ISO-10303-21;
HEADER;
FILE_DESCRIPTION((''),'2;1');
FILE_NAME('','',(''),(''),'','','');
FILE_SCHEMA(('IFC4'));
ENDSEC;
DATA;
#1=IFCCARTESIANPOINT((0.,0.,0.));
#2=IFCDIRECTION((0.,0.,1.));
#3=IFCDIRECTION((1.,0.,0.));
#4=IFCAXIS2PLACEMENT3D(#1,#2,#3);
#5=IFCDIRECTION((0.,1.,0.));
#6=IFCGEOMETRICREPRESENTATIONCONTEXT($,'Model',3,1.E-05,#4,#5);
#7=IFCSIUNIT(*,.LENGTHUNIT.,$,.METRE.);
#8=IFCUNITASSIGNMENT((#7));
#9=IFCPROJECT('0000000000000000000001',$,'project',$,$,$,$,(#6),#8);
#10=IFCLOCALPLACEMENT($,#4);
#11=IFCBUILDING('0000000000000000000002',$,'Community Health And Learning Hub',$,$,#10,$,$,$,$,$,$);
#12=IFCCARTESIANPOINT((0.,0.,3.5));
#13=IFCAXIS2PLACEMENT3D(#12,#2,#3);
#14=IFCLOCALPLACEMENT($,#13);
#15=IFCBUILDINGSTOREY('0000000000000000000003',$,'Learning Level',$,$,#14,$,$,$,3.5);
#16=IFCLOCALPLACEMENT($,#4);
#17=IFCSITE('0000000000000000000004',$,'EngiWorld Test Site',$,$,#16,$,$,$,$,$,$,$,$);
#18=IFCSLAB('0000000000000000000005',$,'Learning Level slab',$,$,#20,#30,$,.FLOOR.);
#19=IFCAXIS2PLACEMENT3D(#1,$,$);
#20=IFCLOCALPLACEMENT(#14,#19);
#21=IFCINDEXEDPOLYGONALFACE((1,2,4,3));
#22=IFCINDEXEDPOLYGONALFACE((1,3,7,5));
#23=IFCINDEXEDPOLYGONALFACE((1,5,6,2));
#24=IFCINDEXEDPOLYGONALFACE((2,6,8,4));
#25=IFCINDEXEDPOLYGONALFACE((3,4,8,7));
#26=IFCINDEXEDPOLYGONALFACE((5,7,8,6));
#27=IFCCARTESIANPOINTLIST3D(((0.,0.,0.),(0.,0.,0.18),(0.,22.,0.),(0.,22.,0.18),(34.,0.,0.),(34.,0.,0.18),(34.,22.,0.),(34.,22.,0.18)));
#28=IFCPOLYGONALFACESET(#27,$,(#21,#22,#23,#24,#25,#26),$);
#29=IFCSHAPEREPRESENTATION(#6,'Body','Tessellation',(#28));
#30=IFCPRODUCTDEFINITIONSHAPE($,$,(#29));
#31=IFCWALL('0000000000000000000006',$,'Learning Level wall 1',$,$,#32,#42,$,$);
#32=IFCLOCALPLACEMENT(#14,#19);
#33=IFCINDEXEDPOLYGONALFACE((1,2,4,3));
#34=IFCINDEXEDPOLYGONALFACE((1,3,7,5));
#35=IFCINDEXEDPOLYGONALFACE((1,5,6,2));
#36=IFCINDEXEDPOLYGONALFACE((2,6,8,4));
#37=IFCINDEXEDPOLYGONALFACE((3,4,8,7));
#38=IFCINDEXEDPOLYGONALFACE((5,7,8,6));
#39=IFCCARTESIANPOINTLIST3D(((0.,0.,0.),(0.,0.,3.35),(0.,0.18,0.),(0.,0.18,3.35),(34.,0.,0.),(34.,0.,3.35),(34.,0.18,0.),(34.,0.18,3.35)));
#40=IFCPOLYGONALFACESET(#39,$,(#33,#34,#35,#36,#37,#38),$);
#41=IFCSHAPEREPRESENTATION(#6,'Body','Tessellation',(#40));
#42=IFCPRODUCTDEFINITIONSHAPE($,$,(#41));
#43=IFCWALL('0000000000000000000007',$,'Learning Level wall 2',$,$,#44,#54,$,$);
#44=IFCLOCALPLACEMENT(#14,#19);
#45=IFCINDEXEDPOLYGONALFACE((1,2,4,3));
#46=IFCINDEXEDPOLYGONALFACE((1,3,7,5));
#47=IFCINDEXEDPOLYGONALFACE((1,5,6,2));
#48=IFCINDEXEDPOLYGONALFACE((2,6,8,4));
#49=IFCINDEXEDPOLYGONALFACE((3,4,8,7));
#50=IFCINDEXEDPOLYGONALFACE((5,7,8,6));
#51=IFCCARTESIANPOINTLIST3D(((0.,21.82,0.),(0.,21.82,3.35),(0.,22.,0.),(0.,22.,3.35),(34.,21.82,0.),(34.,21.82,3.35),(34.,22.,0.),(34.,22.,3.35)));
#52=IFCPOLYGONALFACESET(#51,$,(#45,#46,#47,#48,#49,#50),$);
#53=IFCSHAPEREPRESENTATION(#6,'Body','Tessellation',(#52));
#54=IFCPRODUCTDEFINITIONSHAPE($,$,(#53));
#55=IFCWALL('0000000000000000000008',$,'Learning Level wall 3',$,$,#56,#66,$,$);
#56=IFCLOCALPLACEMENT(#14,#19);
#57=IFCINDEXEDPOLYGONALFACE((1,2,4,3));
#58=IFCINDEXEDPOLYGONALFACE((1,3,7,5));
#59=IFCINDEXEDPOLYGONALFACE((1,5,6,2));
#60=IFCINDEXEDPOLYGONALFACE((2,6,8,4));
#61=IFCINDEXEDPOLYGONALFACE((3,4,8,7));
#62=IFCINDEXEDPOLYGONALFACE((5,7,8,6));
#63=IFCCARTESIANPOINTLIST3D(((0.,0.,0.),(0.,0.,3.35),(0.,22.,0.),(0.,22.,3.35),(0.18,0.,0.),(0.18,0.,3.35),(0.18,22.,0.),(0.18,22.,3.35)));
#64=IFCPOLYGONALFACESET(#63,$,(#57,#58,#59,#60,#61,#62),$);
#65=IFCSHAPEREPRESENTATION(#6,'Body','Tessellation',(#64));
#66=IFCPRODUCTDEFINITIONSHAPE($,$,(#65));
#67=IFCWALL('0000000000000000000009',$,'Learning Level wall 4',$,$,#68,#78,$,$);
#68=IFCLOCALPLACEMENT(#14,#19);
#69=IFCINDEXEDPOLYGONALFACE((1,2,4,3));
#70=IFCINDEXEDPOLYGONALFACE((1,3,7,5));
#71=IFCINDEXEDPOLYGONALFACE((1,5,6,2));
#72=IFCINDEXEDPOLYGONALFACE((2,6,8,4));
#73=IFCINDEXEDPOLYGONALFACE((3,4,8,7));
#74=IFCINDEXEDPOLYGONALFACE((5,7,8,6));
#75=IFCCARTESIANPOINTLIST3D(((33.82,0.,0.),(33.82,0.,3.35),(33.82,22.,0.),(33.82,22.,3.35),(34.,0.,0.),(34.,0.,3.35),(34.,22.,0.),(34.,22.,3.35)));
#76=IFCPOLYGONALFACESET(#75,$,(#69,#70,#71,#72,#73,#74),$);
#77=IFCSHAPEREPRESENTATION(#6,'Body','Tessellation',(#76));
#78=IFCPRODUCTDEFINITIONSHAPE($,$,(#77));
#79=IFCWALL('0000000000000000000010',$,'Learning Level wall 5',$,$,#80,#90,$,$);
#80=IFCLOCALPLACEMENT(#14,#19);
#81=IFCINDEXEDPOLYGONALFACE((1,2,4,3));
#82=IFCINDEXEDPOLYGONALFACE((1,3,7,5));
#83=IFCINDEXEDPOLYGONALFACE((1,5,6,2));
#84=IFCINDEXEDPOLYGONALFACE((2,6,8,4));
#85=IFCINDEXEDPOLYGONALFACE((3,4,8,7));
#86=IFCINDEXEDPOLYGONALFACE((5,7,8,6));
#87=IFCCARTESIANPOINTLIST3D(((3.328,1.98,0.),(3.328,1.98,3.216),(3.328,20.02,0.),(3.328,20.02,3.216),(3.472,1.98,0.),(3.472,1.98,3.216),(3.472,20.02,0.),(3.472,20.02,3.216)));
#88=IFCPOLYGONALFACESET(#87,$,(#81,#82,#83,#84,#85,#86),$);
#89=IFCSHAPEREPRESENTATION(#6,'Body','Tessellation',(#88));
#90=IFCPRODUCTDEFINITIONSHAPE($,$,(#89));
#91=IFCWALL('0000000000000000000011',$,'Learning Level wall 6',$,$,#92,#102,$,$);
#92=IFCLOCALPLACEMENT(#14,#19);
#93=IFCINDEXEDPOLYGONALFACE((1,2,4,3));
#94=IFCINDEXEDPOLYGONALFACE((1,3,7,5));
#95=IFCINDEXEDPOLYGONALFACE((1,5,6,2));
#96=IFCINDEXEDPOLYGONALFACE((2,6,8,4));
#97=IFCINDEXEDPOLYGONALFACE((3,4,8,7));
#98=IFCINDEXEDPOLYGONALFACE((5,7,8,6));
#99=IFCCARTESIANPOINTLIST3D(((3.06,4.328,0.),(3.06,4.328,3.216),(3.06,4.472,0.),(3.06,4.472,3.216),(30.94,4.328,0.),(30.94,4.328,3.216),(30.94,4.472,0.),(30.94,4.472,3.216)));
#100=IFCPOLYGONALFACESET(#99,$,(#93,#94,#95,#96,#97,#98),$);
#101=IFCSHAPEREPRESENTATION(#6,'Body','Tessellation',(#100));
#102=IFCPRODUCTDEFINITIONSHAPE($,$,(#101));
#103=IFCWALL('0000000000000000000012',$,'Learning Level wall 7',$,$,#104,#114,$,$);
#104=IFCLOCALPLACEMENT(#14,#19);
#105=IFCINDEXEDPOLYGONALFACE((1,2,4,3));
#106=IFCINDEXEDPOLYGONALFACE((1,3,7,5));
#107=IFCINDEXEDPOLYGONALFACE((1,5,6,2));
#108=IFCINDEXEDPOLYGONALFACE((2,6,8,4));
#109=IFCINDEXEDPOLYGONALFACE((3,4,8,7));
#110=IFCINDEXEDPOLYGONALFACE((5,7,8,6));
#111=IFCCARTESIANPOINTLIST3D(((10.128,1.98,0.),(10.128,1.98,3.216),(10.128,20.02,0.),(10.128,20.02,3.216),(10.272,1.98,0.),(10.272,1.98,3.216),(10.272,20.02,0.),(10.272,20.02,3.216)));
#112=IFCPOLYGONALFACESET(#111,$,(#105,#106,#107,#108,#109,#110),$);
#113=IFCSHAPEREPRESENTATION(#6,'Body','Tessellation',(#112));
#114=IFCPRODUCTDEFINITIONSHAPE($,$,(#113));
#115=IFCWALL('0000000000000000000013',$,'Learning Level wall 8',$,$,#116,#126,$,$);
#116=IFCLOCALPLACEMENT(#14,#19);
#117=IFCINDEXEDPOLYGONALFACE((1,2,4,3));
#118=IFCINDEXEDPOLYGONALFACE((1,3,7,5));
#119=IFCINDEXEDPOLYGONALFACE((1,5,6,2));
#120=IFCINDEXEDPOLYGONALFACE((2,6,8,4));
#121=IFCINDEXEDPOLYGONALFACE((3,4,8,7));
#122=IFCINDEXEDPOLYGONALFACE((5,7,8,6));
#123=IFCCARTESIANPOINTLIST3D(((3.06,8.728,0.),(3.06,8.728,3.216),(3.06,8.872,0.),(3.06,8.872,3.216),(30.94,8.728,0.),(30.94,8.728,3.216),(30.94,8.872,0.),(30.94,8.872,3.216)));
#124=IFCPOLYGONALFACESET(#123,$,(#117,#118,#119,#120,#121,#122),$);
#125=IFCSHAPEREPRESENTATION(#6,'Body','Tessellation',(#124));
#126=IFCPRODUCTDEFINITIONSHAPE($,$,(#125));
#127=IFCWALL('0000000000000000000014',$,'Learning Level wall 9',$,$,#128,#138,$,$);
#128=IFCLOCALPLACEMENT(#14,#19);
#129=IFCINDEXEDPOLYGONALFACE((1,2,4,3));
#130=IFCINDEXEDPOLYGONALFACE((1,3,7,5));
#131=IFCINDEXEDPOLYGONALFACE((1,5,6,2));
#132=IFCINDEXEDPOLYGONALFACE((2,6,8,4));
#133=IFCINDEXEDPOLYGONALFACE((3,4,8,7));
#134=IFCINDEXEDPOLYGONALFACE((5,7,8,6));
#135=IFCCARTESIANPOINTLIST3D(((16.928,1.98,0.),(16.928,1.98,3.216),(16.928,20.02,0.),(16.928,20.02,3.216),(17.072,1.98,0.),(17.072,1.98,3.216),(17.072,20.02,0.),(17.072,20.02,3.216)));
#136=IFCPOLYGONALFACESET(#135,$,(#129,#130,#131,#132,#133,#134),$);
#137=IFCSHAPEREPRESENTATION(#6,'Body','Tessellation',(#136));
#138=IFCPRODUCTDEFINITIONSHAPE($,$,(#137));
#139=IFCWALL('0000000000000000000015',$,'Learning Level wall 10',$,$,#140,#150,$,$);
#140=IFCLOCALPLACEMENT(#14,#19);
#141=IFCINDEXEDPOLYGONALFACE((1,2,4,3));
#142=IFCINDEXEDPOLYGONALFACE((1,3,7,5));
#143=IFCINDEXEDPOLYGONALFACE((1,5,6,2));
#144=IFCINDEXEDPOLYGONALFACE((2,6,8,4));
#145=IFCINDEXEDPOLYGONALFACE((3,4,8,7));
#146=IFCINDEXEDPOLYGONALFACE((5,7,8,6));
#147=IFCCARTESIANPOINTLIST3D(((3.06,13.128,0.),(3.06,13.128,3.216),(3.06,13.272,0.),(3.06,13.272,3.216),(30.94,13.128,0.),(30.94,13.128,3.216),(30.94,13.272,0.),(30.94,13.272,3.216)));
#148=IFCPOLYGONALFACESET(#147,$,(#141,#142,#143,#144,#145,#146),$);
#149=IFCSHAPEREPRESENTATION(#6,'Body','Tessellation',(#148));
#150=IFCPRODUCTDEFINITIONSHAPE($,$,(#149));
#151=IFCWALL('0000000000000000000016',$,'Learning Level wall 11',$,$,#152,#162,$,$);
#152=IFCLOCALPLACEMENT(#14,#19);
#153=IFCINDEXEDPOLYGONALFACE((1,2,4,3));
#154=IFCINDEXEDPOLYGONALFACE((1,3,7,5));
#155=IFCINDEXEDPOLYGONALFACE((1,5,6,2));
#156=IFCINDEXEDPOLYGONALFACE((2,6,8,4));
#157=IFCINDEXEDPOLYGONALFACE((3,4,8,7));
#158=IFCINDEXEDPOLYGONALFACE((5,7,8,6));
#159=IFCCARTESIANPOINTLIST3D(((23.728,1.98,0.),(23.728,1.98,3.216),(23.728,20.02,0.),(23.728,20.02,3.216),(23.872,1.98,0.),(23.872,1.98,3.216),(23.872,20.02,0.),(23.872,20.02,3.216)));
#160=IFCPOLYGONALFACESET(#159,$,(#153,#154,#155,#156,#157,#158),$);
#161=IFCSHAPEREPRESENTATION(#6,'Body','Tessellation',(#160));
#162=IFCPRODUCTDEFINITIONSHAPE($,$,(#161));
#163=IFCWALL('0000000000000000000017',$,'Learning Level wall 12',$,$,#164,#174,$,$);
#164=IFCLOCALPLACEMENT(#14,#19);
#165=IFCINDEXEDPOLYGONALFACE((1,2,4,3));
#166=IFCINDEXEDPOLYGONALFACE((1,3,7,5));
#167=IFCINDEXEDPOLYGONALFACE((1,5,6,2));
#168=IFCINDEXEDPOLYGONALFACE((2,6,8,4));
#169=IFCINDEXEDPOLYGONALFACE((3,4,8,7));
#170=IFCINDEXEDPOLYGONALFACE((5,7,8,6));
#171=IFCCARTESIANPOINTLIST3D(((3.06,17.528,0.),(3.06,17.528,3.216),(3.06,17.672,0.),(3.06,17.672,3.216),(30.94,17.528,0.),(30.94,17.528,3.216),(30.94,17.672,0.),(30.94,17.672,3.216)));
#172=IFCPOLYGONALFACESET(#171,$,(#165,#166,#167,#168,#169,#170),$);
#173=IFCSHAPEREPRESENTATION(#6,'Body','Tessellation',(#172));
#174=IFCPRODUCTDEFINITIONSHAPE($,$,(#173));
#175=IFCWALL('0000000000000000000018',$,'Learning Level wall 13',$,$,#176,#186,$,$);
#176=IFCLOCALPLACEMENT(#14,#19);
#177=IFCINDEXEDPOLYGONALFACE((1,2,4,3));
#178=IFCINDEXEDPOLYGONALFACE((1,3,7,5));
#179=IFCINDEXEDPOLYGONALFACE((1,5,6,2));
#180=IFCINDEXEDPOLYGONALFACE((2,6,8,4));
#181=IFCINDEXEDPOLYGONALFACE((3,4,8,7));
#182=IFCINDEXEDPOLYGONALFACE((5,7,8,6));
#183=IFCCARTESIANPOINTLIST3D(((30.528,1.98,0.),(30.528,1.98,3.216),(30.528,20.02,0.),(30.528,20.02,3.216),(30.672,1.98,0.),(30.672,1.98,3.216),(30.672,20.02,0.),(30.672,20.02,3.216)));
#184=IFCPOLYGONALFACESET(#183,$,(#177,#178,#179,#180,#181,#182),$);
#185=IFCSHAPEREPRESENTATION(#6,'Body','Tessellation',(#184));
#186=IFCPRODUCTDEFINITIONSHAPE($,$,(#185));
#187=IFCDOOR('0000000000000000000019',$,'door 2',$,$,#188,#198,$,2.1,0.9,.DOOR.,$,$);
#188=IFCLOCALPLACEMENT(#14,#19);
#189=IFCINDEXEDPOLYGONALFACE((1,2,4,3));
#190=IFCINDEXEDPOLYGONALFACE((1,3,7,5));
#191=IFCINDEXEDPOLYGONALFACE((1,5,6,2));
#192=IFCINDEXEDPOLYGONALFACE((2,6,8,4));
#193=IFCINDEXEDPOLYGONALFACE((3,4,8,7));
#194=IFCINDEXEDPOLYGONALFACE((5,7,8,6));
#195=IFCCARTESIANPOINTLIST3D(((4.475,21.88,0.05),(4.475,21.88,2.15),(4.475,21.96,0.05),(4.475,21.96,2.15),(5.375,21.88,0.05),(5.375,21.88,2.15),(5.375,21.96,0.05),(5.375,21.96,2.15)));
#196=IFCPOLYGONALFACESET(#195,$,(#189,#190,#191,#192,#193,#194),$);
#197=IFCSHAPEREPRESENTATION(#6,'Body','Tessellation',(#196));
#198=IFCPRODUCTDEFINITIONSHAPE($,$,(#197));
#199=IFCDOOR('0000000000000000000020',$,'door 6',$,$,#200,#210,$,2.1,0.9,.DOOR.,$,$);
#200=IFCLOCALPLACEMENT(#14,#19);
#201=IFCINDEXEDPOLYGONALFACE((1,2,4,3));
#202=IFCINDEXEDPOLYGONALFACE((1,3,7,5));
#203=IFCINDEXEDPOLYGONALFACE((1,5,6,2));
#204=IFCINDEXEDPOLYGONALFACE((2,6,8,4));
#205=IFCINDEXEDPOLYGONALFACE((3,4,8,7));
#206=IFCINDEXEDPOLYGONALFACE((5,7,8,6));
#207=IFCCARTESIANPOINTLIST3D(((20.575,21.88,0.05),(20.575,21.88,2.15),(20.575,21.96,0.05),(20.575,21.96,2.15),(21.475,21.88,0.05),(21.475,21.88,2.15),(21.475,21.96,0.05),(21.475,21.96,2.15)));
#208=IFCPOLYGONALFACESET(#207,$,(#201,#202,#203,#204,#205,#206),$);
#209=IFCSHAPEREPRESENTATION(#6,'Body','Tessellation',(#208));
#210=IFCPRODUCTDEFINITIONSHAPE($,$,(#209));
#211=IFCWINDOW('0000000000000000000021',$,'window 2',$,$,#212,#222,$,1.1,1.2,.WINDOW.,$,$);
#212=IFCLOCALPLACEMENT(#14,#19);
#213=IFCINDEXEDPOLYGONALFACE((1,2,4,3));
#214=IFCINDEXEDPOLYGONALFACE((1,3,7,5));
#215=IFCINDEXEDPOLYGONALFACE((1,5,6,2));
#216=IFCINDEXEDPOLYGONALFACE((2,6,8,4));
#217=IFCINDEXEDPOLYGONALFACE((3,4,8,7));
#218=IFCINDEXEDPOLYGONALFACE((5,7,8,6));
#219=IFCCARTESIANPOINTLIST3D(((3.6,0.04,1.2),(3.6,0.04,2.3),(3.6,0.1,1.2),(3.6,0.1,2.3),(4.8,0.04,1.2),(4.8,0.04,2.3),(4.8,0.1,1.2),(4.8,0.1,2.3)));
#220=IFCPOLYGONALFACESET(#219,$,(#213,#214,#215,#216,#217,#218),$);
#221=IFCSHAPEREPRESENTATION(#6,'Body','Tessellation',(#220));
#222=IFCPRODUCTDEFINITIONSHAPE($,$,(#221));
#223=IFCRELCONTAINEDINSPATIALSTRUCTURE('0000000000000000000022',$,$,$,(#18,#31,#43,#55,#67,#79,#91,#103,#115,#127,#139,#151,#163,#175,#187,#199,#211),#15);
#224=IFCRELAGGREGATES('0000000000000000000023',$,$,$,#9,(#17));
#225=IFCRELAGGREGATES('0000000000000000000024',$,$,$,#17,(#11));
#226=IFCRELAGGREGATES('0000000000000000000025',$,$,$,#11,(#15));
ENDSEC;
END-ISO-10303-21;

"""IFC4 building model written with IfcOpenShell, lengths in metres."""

from ifc_helpers import new_model, si_unit, direction, frame, origin_with_axes, origin_2d_with_axis, place, context, project, spatial, rectangle, extrude, element, save


model = new_model("IFC4")

# Units and contexts
model_context = context("Model", 3, precision=1e-05, world=origin_with_axes(), true_north=direction((0.0, 1.0, 0.0)))
ifc_project = project(units=[si_unit("LENGTHUNIT", "METRE")], contexts=[model_context])

# Site, building, storey
site_placement = place(None, origin_with_axes())
site = spatial("IfcSite", under=ifc_project, at=site_placement, Name="EngiWorld Test Site")
building_placement = place(None, origin_with_axes())
building = spatial("IfcBuilding", under=site, at=building_placement, Name="Community Health And Learning Hub")
storey_placement = place(None, frame((0.0, 0.0, 3.5), z_axis=(0.0, 0.0, 1.0), x_axis=(1.0, 0.0, 0.0)))
storey = spatial("IfcBuildingStorey", under=building, at=storey_placement, Name="Learning Level", Elevation=3.5)

# Slab
slab_placement = place(None, frame((17.0, 11.0, 3.5), z_axis=(0.0, 0.0, 1.0), x_axis=(1.0, 0.0, 0.0)))
element("IfcSlab", 1, at=slab_placement, inside=storey, Name="Learning Level slab", PredefinedType="FLOOR", context=model_context, shape_type="SweptSolid", body=[
    extrude(rectangle(XDim=34.0, YDim=22.0, at=origin_2d_with_axis()), origin_with_axes(), (0.0, 0.0, 1.0), 0.18),
])

# Walls
for number, where, z_axis, x_axis, name in (
    (2, (17.0, 0.09, 3.5), (0.0, 0.0, 1.0), (1.0, 0.0, 0.0), "Learning Level wall 1"),
    (3, (17.0, 21.91, 3.5), (0.0, 0.0, 1.0), (1.0, 0.0, 0.0), "Learning Level wall 2"),
):
    element("IfcWall", number, at=place(None, frame(where, z_axis=z_axis, x_axis=x_axis)), inside=storey, Name=name, context=model_context, shape_type="SweptSolid", body=[
        extrude(rectangle(XDim=34.0, YDim=0.18, at=origin_2d_with_axis()), origin_with_axes(), (0.0, 0.0, 1.0), 3.35),
    ])
for number, where, z_axis, x_axis, name in (
    (4, (0.09, 11.0, 3.5), (0.0, 0.0, 1.0), (1.0, 0.0, 0.0), "Learning Level wall 3"),
    (5, (33.91, 11.0, 3.5), (0.0, 0.0, 1.0), (1.0, 0.0, 0.0), "Learning Level wall 4"),
):
    element("IfcWall", number, at=place(None, frame(where, z_axis=z_axis, x_axis=x_axis)), inside=storey, Name=name, context=model_context, shape_type="SweptSolid", body=[
        extrude(rectangle(XDim=0.18, YDim=22.0, at=origin_2d_with_axis()), origin_with_axes(), (0.0, 0.0, 1.0), 3.35),
    ])
wall_1_placement = place(None, frame((3.4, 11.0, 3.5), z_axis=(0.0, 0.0, 1.0), x_axis=(1.0, 0.0, 0.0)))
element("IfcWall", 6, at=wall_1_placement, inside=storey, Name="Learning Level wall 5", context=model_context, shape_type="SweptSolid", body=[
    extrude(rectangle(XDim=0.144, YDim=18.04, at=origin_2d_with_axis()), origin_with_axes(), (0.0, 0.0, 1.0), 3.216),
])
wall_2_placement = place(None, frame((17.0, 4.4, 3.5), z_axis=(0.0, 0.0, 1.0), x_axis=(1.0, 0.0, 0.0)))
element("IfcWall", 7, at=wall_2_placement, inside=storey, Name="Learning Level wall 6", context=model_context, shape_type="SweptSolid", body=[
    extrude(rectangle(XDim=27.88, YDim=0.144, at=origin_2d_with_axis()), origin_with_axes(), (0.0, 0.0, 1.0), 3.216),
])
wall_3_placement = place(None, frame((10.2, 11.0, 3.5), z_axis=(0.0, 0.0, 1.0), x_axis=(1.0, 0.0, 0.0)))
element("IfcWall", 8, at=wall_3_placement, inside=storey, Name="Learning Level wall 7", context=model_context, shape_type="SweptSolid", body=[
    extrude(rectangle(XDim=0.144, YDim=18.04, at=origin_2d_with_axis()), origin_with_axes(), (0.0, 0.0, 1.0), 3.216),
])
wall_4_placement = place(None, frame((17.0, 8.8, 3.5), z_axis=(0.0, 0.0, 1.0), x_axis=(1.0, 0.0, 0.0)))
element("IfcWall", 9, at=wall_4_placement, inside=storey, Name="Learning Level wall 8", context=model_context, shape_type="SweptSolid", body=[
    extrude(rectangle(XDim=27.88, YDim=0.144, at=origin_2d_with_axis()), origin_with_axes(), (0.0, 0.0, 1.0), 3.216),
])
wall_5_placement = place(None, frame((17.0, 11.0, 3.5), z_axis=(0.0, 0.0, 1.0), x_axis=(1.0, 0.0, 0.0)))
element("IfcWall", 10, at=wall_5_placement, inside=storey, Name="Learning Level wall 9", context=model_context, shape_type="SweptSolid", body=[
    extrude(rectangle(XDim=0.144, YDim=18.04, at=origin_2d_with_axis()), origin_with_axes(), (0.0, 0.0, 1.0), 3.216),
])
wall_6_placement = place(None, frame((17.0, 13.2, 3.5), z_axis=(0.0, 0.0, 1.0), x_axis=(1.0, 0.0, 0.0)))
element("IfcWall", 11, at=wall_6_placement, inside=storey, Name="Learning Level wall 10", context=model_context, shape_type="SweptSolid", body=[
    extrude(rectangle(XDim=27.88, YDim=0.144, at=origin_2d_with_axis()), origin_with_axes(), (0.0, 0.0, 1.0), 3.216),
])
wall_7_placement = place(None, frame((23.8, 11.0, 3.5), z_axis=(0.0, 0.0, 1.0), x_axis=(1.0, 0.0, 0.0)))
element("IfcWall", 12, at=wall_7_placement, inside=storey, Name="Learning Level wall 11", context=model_context, shape_type="SweptSolid", body=[
    extrude(rectangle(XDim=0.144, YDim=18.04, at=origin_2d_with_axis()), origin_with_axes(), (0.0, 0.0, 1.0), 3.216),
])
wall_8_placement = place(None, frame((17.0, 17.6, 3.5), z_axis=(0.0, 0.0, 1.0), x_axis=(1.0, 0.0, 0.0)))
element("IfcWall", 13, at=wall_8_placement, inside=storey, Name="Learning Level wall 12", context=model_context, shape_type="SweptSolid", body=[
    extrude(rectangle(XDim=27.88, YDim=0.144, at=origin_2d_with_axis()), origin_with_axes(), (0.0, 0.0, 1.0), 3.216),
])
wall_9_placement = place(None, frame((30.6, 11.0, 3.5), z_axis=(0.0, 0.0, 1.0), x_axis=(1.0, 0.0, 0.0)))
element("IfcWall", 14, at=wall_9_placement, inside=storey, Name="Learning Level wall 13", context=model_context, shape_type="SweptSolid", body=[
    extrude(rectangle(XDim=0.144, YDim=18.04, at=origin_2d_with_axis()), origin_with_axes(), (0.0, 0.0, 1.0), 3.216),
])

# Doors
for number, where, z_axis, x_axis, name in (
    (15, (4.925, 21.92, 3.55), (0.0, 0.0, 1.0), (1.0, 0.0, 0.0), "door 2"),
    (16, (21.025, 21.92, 3.55), (0.0, 0.0, 1.0), (1.0, 0.0, 0.0), "door 6"),
):
    element("IfcDoor", number, at=place(None, frame(where, z_axis=z_axis, x_axis=x_axis)), inside=storey, Name=name, OverallHeight=2.1, OverallWidth=0.9, PredefinedType="DOOR", context=model_context, shape_type="SweptSolid", body=[
        extrude(rectangle(XDim=0.9, YDim=0.08, at=origin_2d_with_axis()), origin_with_axes(), (0.0, 0.0, 1.0), 2.1),
    ])

# Window
for number, where, z_axis, x_axis, name in (
    (17, (4.2, 0.07, 4.7), (0.0, 0.0, 1.0), (1.0, 0.0, 0.0), "window 2"),
):
    element("IfcWindow", number, at=place(None, frame(where, z_axis=z_axis, x_axis=x_axis)), inside=storey, Name=name, OverallHeight=1.1, OverallWidth=1.2, PredefinedType="WINDOW", context=model_context, shape_type="SweptSolid", body=[
        extrude(rectangle(XDim=1.2, YDim=0.06, at=origin_2d_with_axis()), origin_with_axes(), (0.0, 0.0, 1.0), 1.1),
    ])

save(model, "model.ifc")
